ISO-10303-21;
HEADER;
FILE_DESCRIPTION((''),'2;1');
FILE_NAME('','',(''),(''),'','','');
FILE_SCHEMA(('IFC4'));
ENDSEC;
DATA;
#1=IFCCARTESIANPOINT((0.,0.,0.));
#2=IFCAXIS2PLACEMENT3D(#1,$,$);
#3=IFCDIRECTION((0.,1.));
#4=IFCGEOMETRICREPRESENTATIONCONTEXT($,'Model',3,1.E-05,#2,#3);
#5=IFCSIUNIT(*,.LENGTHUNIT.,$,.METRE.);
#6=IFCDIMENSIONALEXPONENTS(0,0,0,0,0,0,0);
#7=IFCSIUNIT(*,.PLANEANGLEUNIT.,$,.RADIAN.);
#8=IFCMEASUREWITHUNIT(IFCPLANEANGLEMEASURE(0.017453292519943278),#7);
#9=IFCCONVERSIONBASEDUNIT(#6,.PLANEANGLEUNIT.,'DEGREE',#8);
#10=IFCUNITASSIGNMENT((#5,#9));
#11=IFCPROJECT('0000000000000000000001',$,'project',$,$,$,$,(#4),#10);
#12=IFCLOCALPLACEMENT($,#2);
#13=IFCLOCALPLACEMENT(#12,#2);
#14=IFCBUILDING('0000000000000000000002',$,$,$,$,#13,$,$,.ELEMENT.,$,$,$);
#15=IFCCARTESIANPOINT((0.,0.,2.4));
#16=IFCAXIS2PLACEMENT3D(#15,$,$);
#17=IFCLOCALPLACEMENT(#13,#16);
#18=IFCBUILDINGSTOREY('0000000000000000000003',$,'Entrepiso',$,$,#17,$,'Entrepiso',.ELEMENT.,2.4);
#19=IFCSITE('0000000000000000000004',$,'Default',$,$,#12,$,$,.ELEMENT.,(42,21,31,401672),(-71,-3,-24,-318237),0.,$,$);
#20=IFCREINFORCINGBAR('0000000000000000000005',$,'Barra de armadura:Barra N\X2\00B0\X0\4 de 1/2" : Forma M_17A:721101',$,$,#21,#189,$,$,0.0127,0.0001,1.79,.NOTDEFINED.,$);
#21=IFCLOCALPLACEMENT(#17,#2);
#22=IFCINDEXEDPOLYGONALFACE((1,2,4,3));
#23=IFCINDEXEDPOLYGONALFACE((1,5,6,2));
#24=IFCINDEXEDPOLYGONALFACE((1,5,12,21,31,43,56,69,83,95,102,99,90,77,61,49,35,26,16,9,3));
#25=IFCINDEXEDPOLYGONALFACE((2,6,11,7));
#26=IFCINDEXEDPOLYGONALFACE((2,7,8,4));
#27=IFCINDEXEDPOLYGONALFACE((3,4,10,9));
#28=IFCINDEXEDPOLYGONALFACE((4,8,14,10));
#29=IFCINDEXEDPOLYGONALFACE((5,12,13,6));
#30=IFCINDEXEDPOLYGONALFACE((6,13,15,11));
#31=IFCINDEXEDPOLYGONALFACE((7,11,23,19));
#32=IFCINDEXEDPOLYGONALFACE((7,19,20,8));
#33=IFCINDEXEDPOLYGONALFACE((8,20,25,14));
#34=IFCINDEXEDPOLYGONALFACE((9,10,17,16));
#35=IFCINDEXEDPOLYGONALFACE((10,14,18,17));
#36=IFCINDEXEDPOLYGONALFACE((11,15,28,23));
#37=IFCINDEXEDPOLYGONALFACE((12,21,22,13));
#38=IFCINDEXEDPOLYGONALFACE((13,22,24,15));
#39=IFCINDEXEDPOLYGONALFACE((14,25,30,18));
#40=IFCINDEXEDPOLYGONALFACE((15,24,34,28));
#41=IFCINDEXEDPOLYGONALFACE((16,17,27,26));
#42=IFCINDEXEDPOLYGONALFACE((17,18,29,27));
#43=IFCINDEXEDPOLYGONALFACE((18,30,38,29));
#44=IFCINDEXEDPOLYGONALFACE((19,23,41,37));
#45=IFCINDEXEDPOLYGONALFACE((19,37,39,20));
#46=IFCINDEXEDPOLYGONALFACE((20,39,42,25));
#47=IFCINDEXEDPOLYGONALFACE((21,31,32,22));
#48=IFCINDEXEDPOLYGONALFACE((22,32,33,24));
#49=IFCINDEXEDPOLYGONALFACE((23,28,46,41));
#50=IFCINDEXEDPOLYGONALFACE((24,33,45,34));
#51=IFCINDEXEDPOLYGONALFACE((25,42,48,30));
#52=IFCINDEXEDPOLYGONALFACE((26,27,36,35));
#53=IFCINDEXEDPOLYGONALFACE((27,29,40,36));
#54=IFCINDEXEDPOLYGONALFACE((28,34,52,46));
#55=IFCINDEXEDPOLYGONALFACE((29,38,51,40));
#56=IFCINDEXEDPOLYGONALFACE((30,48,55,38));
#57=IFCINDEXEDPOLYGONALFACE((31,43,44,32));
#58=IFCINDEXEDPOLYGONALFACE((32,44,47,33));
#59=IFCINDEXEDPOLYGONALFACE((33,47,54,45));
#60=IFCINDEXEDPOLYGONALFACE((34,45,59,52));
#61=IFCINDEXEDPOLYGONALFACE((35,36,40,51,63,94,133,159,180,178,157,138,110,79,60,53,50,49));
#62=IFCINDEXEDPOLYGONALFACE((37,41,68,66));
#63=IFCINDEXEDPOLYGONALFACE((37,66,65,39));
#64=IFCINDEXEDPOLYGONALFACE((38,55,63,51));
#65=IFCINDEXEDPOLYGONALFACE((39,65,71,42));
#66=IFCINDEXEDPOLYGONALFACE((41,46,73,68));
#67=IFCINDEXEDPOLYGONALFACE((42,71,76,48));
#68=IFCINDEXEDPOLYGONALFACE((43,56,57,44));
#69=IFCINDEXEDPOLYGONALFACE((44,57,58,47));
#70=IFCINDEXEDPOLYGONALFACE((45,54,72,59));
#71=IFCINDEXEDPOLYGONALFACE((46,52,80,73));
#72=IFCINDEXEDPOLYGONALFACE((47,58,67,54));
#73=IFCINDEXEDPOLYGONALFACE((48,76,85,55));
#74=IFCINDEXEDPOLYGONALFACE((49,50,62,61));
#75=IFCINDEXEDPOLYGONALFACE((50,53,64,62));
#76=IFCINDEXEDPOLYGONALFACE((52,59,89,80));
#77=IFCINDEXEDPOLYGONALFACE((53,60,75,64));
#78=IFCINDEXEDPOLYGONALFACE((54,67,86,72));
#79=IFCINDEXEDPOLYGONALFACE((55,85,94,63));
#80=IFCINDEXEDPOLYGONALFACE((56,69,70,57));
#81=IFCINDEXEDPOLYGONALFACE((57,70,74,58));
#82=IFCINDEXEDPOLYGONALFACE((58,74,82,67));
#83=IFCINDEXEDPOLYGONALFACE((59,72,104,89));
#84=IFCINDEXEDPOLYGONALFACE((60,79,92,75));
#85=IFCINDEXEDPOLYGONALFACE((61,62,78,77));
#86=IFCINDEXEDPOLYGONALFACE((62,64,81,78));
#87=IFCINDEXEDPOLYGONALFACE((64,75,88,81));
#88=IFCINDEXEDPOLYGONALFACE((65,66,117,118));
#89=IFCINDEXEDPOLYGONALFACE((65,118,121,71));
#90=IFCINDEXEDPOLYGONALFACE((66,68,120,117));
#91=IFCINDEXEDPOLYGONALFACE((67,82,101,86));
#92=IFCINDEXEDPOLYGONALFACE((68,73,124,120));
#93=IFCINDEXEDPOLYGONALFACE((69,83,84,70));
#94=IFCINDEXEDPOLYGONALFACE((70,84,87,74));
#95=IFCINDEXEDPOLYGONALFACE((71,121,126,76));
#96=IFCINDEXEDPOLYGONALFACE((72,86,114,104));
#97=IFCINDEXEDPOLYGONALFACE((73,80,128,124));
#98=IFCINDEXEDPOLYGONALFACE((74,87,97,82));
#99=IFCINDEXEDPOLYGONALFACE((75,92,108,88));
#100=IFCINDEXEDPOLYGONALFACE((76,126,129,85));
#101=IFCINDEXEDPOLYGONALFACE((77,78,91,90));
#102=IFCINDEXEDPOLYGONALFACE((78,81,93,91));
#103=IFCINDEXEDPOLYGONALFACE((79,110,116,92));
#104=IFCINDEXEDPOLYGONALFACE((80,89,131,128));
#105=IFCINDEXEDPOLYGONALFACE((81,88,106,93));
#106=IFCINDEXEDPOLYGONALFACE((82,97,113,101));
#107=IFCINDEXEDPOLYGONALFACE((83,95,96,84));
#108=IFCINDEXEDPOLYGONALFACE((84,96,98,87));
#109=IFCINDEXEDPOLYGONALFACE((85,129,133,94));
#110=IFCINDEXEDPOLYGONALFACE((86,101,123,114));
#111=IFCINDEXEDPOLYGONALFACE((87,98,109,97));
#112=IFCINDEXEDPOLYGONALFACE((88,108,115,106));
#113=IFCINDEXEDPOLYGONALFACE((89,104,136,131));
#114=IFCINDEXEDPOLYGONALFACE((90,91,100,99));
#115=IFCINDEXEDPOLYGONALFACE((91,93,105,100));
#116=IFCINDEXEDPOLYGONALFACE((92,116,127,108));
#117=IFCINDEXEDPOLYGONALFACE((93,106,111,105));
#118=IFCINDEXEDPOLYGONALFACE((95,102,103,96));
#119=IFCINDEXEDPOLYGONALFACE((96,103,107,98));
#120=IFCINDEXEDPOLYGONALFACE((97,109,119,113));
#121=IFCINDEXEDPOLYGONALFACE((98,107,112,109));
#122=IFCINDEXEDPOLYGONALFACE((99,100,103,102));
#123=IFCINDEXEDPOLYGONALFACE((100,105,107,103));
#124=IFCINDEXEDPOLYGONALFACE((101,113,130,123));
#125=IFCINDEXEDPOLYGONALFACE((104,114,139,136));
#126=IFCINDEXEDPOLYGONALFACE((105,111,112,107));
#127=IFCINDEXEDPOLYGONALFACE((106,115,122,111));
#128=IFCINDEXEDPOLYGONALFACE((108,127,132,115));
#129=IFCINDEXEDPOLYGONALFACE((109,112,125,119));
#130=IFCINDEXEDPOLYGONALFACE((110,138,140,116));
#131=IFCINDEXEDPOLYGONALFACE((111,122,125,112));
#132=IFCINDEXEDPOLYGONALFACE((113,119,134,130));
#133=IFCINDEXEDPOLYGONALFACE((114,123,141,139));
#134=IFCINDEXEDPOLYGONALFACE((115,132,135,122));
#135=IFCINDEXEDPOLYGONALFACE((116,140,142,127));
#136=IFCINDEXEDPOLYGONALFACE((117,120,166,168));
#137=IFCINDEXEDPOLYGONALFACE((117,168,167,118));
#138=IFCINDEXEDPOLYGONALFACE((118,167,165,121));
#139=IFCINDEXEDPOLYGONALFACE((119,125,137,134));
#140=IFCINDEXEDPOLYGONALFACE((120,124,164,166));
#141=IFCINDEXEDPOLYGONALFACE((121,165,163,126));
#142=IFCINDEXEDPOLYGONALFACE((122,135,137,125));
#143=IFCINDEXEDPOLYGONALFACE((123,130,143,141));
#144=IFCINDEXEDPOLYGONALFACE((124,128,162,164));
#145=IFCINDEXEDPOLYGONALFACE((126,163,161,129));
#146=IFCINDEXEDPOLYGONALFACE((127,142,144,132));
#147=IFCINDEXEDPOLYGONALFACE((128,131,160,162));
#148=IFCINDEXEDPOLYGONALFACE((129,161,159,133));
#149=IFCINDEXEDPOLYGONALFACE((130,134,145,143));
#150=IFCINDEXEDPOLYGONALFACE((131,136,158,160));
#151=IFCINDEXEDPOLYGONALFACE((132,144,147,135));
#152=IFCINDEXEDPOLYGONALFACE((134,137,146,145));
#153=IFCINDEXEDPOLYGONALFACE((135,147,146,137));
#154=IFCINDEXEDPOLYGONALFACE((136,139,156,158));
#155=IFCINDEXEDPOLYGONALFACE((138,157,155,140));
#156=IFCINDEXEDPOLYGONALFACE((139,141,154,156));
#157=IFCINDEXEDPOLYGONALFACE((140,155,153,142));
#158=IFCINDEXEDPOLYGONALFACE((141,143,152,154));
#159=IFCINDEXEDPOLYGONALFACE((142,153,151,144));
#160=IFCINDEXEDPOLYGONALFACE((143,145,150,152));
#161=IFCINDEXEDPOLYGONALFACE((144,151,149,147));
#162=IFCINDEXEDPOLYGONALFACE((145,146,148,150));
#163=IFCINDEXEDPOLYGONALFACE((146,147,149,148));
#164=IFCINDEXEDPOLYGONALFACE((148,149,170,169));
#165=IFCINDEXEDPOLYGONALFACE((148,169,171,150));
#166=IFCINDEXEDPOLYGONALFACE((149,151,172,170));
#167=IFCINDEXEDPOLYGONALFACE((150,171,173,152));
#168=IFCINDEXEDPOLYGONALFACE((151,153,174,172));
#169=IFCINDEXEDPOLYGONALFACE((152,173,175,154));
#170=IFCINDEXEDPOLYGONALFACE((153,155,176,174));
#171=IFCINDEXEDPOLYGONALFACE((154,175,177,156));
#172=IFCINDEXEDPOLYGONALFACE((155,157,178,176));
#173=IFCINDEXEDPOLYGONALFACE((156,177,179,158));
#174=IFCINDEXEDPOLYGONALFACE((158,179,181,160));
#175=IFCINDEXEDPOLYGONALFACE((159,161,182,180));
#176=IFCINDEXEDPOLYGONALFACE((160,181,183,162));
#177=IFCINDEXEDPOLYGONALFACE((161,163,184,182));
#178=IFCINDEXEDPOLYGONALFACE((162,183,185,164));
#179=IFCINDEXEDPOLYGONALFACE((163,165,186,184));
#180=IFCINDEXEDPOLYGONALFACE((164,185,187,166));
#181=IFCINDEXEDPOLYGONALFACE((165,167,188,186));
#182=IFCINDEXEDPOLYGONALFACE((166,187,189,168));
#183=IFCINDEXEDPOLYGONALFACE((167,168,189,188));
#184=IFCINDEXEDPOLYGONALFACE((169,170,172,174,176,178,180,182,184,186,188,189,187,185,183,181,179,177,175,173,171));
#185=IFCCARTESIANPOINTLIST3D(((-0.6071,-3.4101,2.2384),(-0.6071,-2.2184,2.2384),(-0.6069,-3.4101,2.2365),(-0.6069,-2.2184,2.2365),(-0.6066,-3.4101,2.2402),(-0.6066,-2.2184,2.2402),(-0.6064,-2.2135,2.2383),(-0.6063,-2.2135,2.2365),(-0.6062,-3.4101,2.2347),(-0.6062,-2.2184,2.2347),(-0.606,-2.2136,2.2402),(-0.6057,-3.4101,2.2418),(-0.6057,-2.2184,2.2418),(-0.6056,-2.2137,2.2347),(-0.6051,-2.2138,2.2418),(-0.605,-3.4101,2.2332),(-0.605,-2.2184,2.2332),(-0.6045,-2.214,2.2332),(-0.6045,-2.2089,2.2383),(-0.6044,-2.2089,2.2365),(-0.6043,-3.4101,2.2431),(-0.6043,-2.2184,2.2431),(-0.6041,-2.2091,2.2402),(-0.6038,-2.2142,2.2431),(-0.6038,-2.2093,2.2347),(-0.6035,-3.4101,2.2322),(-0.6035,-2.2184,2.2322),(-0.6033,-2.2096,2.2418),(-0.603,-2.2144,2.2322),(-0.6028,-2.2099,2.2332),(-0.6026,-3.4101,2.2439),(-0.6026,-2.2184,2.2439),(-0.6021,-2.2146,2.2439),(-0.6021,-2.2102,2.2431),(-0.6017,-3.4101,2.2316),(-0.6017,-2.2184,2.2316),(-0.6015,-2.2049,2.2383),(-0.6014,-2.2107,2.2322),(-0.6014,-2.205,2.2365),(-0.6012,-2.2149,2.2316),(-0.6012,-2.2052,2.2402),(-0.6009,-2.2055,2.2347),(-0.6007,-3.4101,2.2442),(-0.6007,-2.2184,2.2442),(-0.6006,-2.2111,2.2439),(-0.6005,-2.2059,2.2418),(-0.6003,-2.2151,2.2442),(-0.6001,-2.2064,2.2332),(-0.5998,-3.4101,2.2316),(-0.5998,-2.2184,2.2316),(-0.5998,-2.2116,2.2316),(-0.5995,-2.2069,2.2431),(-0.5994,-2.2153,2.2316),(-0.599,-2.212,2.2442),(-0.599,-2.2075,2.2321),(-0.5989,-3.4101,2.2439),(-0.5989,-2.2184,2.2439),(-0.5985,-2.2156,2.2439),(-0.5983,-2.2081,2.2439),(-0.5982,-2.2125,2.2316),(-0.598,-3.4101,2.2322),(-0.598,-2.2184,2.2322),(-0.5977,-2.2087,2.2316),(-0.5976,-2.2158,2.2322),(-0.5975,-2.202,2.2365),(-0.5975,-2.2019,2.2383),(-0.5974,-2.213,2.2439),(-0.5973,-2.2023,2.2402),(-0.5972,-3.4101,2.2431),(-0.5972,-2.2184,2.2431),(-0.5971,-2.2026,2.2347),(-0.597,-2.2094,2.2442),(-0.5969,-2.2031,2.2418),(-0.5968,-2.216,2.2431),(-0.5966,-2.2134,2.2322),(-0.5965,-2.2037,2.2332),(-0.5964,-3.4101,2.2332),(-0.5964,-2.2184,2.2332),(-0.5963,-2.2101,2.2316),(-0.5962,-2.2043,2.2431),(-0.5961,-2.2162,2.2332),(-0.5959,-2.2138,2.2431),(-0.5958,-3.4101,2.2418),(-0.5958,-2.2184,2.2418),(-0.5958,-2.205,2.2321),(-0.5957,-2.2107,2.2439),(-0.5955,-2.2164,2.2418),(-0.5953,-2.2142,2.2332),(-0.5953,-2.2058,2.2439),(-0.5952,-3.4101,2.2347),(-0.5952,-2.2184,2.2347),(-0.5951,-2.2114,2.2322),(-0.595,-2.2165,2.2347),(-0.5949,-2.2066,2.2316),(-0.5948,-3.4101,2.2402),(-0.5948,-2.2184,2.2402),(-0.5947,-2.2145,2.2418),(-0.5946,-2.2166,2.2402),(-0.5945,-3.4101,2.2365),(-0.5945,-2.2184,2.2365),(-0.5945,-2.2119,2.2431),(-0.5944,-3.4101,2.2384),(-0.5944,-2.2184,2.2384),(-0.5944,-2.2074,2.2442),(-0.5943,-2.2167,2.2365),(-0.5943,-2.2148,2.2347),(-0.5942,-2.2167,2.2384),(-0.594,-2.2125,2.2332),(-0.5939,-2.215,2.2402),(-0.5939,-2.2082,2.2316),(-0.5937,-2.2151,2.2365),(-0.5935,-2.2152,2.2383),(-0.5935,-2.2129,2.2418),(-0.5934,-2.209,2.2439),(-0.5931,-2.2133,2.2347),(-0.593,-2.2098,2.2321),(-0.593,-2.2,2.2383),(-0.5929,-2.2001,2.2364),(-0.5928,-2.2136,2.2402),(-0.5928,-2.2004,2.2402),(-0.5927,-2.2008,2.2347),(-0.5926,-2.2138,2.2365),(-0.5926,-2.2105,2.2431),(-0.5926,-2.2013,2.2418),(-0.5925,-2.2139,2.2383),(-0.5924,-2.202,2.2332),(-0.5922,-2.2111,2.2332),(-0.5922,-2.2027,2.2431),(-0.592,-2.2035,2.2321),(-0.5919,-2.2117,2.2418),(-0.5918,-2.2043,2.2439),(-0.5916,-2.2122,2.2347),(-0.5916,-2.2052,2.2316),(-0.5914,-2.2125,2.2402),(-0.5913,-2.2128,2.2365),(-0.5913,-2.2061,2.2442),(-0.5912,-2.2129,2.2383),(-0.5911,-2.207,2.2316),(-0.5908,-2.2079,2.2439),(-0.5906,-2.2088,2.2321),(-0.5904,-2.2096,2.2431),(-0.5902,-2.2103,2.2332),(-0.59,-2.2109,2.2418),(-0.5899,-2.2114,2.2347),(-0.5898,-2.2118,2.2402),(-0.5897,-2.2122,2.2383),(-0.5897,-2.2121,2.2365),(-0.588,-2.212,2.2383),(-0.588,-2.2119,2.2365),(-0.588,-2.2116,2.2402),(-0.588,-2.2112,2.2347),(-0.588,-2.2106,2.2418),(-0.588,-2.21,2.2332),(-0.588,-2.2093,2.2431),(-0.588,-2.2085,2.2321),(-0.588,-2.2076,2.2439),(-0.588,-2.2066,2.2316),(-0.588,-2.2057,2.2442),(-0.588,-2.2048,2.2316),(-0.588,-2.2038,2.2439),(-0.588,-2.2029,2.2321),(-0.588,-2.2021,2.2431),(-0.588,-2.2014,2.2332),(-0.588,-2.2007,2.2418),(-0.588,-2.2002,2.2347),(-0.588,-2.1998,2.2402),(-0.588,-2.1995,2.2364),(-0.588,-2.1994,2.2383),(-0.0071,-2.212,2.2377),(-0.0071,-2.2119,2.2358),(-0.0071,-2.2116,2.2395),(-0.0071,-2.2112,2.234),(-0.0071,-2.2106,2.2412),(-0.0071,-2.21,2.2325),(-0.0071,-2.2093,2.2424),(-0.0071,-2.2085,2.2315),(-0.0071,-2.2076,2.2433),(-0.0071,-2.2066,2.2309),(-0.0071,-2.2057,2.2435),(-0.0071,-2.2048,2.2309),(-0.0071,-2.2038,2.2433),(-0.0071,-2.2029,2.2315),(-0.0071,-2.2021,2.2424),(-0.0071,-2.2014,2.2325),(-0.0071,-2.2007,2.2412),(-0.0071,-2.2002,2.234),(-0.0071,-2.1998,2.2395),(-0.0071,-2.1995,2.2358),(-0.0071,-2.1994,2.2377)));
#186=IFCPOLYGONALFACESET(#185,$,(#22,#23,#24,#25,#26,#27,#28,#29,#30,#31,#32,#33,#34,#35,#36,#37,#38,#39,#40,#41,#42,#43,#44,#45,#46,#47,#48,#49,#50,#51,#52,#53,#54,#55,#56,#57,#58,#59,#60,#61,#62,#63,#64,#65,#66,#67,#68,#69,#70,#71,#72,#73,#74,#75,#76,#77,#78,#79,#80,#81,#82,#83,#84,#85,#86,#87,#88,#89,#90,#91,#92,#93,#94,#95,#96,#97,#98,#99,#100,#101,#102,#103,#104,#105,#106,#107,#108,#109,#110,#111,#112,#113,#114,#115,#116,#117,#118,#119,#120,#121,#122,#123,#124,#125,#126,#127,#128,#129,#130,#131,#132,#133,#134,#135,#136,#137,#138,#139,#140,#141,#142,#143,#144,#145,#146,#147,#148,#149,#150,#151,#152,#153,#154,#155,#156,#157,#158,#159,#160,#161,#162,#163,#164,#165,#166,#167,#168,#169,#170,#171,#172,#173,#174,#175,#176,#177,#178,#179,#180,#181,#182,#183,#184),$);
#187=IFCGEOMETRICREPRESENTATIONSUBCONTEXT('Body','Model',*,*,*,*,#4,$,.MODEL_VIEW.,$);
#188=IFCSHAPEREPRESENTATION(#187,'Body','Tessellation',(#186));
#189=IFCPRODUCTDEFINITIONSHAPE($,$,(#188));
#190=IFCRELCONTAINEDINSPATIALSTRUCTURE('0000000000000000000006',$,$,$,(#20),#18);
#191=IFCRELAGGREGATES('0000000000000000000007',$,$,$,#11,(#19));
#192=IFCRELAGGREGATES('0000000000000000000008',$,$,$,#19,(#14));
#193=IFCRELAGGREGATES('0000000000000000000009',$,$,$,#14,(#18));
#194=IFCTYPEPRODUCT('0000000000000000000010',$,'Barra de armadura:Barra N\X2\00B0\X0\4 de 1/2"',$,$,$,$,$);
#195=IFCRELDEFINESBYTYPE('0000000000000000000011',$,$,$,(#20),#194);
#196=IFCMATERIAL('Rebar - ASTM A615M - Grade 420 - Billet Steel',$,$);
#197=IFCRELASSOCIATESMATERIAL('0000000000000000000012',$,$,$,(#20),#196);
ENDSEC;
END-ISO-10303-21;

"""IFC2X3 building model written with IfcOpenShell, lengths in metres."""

from ifc_helpers import new_model, entity, si_unit, converted_unit, direction, frame, origin, place, context, subcontext, project, spatial, material, type_object, element, save


model = new_model("IFC2X3")

# Units and contexts
model_context = context("Model", 3, precision=1e-05, world=origin(), true_north=direction((0.0, 1.0)))
body_context = subcontext(model_context, "Body", "Model", "MODEL_VIEW")
ifc_project = project(units=[si_unit("LENGTHUNIT", "METRE"), converted_unit("PLANEANGLEUNIT", "DEGREE", entity("IfcPlaneAngleMeasure", 0.017453292519943278), si_unit("PLANEANGLEUNIT", "RADIAN"), dimensions=[0, 0, 0, 0, 0, 0, 0])], contexts=[model_context])

# Site, building, storey
site_placement = place(None, origin())
site = spatial("IfcSite", under=ifc_project, at=site_placement, Name="Default", CompositionType="ELEMENT", RefLatitude=(42, 21, 31, 401672), RefLongitude=(-71, -3, -24, -318237), RefElevation=0.0)
building_placement = place(site_placement, origin())
building = spatial("IfcBuilding", under=site, at=building_placement, CompositionType="ELEMENT")
storey_placement = place(building_placement, frame((0.0, 0.0, 2.4)))
storey = spatial("IfcBuildingStorey", under=building, at=storey_placement, Name="Entrepiso", LongName="Entrepiso", CompositionType="ELEMENT", Elevation=2.4)

# Reinforcing bar
ifc_material = material(Name="Rebar - ASTM A615M - Grade 420 - Billet Steel")
type_product_1 = type_object("IfcTypeProduct", Name="Barra de armadura:Barra N°4 de 1/2\"")
reinforcing_bar_1_placement = place(storey_placement, origin())
element("IfcReinforcingBar", 1, at=reinforcing_bar_1_placement, inside=storey, type_object=type_product_1, material=ifc_material, Name="Barra de armadura:Barra N°4 de 1/2\" : Forma M_17A:721101", BarLength=1.79, BarRole="NOTDEFINED", CrossSectionArea=0.0001, NominalDiameter=0.0127, context=body_context, shape_type="AdvancedSweptSolid", body=[
    entity("IfcSweptDiskSolid", entity("IfcCompositeCurve", [entity("IfcCompositeCurveSegment", "CONTINUOUS", True, entity("IfcPolyline", [entity("IfcCartesianPoint", [-0.6007, -3.4101, 2.2379]), entity("IfcCartesianPoint", [-0.6007, -2.2184, 2.2379])])), entity("IfcCompositeCurveSegment", "CONTINUOUS", True, entity("IfcTrimmedCurve", entity("IfcCircle", entity("IfcAxis2Placement3D", entity("IfcCartesianPoint", [-0.588, -2.2184, 2.2379]), entity("IfcDirection", [-0.001144, 0.0, -0.999999]), entity("IfcDirection", [0.0, 1.0, 0.0])), 0.0127), [entity("IfcParameterValue", 270.0)], [entity("IfcParameterValue", 360.0)], True, "PARAMETER")), entity("IfcCompositeCurveSegment", "CONTINUOUS", True, entity("IfcPolyline", [entity("IfcCartesianPoint", [-0.588, -2.2057, 2.2379]), entity("IfcCartesianPoint", [-0.0071, -2.2057, 2.2372])]))], False), 0.0063, None, 0.0, 92.0),
])

save(model, "model.ifc")
